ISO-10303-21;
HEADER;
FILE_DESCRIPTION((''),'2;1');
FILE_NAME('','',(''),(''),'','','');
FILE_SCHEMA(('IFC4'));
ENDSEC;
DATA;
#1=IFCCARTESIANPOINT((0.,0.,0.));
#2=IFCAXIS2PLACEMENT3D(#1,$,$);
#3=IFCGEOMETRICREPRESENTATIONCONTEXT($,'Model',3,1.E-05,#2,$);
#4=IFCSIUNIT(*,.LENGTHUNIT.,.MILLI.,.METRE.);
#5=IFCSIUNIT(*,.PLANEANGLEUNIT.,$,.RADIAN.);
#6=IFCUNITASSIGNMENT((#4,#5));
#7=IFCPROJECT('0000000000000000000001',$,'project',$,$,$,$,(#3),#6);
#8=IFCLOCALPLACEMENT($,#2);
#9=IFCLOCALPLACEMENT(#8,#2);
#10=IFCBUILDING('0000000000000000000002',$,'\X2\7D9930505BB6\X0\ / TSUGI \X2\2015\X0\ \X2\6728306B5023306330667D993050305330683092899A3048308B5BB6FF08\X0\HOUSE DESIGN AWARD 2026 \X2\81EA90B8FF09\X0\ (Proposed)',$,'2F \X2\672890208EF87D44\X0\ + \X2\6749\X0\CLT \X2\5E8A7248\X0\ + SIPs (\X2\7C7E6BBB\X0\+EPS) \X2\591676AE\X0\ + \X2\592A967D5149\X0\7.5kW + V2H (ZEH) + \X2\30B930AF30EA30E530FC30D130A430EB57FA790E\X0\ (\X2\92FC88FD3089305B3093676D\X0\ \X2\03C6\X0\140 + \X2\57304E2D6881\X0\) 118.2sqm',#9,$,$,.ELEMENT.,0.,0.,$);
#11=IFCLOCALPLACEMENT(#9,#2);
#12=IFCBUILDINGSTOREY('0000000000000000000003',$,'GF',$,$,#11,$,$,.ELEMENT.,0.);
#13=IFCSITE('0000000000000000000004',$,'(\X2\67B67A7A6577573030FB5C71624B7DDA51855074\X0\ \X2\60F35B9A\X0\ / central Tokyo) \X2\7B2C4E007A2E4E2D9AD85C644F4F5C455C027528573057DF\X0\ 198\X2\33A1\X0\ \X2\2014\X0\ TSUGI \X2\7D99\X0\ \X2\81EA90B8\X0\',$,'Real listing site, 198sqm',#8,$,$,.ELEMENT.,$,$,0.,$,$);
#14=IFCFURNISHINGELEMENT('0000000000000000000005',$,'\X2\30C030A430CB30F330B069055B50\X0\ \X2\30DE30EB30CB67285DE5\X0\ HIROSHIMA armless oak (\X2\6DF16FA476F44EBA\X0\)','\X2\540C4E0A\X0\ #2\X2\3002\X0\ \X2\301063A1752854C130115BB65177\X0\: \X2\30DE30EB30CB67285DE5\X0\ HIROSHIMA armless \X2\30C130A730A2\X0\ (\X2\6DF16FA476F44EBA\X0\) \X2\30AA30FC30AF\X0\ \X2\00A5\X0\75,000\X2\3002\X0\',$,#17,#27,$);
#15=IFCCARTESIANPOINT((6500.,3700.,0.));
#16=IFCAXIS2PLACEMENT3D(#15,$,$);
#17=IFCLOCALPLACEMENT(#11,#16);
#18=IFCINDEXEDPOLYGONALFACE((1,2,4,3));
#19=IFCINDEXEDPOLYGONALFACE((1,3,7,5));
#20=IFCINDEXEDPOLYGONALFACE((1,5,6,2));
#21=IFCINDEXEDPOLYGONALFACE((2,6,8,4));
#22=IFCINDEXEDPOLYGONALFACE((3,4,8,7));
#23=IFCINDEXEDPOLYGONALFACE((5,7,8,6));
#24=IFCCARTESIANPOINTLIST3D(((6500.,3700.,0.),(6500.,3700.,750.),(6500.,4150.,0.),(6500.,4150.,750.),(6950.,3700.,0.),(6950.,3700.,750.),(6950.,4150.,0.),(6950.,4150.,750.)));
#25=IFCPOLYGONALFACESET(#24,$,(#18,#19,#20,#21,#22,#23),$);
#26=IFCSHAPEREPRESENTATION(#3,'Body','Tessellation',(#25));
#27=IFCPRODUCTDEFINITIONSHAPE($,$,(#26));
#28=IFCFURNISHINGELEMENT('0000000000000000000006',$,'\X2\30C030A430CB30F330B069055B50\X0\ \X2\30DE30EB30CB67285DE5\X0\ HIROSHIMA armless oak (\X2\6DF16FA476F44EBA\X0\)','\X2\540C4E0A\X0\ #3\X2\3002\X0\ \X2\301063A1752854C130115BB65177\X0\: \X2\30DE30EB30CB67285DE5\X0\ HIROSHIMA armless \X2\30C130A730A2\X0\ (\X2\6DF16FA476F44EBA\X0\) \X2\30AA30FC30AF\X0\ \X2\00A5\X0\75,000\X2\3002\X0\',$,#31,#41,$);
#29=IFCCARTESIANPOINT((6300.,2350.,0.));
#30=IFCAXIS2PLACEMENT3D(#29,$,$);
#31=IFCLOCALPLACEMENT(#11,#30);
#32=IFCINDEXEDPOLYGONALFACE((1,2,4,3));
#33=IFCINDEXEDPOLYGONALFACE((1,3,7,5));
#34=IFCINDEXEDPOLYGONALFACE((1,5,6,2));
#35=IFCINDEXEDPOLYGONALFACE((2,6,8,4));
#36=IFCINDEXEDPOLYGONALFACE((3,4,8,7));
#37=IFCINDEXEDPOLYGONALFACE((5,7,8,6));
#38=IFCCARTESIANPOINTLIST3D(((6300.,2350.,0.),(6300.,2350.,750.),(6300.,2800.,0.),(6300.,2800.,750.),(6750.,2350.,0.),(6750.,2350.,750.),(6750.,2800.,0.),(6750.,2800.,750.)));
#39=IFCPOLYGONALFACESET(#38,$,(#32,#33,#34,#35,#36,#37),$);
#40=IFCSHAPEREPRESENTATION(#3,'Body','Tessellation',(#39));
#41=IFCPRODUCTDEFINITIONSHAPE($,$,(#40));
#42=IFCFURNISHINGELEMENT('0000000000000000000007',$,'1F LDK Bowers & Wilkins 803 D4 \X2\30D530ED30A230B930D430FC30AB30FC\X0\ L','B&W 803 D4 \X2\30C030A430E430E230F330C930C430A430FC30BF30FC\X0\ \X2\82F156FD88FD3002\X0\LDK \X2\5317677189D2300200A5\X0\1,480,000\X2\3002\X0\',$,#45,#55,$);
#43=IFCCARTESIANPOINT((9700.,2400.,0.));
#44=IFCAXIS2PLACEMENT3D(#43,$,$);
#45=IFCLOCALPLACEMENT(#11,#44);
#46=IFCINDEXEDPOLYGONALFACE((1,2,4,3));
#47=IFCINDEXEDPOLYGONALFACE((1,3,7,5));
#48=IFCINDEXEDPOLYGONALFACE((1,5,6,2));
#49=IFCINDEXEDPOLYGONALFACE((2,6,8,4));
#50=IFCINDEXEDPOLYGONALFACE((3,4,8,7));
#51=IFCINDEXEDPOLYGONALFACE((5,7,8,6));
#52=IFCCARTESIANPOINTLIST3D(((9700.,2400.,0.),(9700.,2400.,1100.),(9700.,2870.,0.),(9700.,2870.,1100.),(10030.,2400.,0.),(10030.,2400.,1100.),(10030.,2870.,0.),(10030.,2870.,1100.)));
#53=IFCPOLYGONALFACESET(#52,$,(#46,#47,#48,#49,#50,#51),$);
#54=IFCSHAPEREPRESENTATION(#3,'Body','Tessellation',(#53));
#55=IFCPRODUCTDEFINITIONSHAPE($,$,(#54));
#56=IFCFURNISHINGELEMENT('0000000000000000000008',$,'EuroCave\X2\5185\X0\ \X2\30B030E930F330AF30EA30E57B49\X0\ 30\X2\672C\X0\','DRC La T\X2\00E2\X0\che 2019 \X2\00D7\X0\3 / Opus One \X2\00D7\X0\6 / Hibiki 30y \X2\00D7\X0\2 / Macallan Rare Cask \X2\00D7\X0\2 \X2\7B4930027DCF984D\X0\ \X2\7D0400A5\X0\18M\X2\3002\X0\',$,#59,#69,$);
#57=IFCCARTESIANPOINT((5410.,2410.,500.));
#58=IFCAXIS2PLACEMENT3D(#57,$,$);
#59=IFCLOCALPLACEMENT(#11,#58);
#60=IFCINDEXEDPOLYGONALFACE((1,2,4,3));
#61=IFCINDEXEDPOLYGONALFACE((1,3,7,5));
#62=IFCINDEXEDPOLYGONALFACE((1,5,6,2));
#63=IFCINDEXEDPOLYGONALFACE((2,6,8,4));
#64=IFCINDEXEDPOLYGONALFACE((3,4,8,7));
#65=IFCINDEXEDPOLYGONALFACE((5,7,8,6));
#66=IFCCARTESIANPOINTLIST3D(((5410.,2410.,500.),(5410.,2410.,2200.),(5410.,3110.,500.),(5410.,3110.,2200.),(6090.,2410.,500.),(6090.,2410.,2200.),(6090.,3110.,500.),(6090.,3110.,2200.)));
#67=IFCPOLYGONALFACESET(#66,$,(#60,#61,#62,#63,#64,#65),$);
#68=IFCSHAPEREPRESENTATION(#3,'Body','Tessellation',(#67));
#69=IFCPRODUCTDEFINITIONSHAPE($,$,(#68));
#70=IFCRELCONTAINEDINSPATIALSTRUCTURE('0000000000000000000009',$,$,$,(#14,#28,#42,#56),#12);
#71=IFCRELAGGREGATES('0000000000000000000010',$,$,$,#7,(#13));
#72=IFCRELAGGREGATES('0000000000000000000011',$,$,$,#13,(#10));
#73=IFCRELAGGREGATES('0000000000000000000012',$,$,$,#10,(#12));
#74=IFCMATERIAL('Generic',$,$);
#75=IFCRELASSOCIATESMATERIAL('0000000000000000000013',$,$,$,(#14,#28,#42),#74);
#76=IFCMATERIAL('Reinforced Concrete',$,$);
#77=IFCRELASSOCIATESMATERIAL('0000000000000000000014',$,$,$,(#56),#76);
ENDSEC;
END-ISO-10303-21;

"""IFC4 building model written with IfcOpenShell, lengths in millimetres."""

from ifc_helpers import new_model, si_unit, frame, frame_2d, origin, place, context, project, spatial, rectangle, extrude, material, element, save


model = new_model("IFC4")

# Units and contexts
model_context = context("Model", 3, precision=1e-05, world=origin())
ifc_project = project(units=[si_unit("LENGTHUNIT", "METRE", prefix="MILLI"), si_unit("PLANEANGLEUNIT", "RADIAN")], contexts=[model_context])

# Site, building, storey
site_placement = place(None, origin())
site = spatial("IfcSite", under=ifc_project, at=site_placement, Name="(架空敷地・山手線内側 想定 / central Tokyo) 第一種中高層住居専用地域 198㎡ — TSUGI 継 自邸", ObjectType="Real listing site, 198sqm", CompositionType="ELEMENT", RefElevation=0.0)
building_placement = place(site_placement, origin())
building = spatial("IfcBuilding", under=site, at=building_placement, Name="継ぐ家 / TSUGI ― 木に倣って継ぐことを覚える家（HOUSE DESIGN AWARD 2026 自邸） (Proposed)", ObjectType="2F 木造軸組 + 杉CLT 床版 + SIPs (籾殻+EPS) 外皮 + 太陽光7.5kW + V2H (ZEH) + スクリューパイル基礎 (鋼製らせん杭 φ140 + 地中梁) 118.2sqm", CompositionType="ELEMENT", ElevationOfRefHeight=0.0, ElevationOfTerrain=0.0)
storey_placement = place(building_placement, origin())
storey = spatial("IfcBuildingStorey", under=building, at=storey_placement, Name="GF", CompositionType="ELEMENT", Elevation=0.0)

# Shared definitions
ifc_material_1 = material(Name="Generic")

# Furnishing elements
furnishing_1_placement = place(storey_placement, frame((6500.0, 3700.0, 0.0)))
element("IfcFurnishingElement", 1, at=furnishing_1_placement, inside=storey, material=ifc_material_1, Name="ダイニング椅子 マルニ木工 HIROSHIMA armless oak (深澤直人)", Description="同上 #2。 【採用品】家具: マルニ木工 HIROSHIMA armless チェア (深澤直人) オーク ¥75,000。", context=model_context, shape_type="SweptSolid", body=[
    extrude(rectangle(XDim=450.0, YDim=450.0, at=frame_2d((225.0, 225.0))), frame((6500.0, 3700.0, 0.0)), (0.0, 0.0, 1.0), 750.0),
])
furnishing_2_placement = place(storey_placement, frame((6300.0, 2350.0, 0.0)))
element("IfcFurnishingElement", 2, at=furnishing_2_placement, inside=storey, material=ifc_material_1, Name="ダイニング椅子 マルニ木工 HIROSHIMA armless oak (深澤直人)", Description="同上 #3。 【採用品】家具: マルニ木工 HIROSHIMA armless チェア (深澤直人) オーク ¥75,000。", context=model_context, shape_type="SweptSolid", body=[
    extrude(rectangle(XDim=450.0, YDim=450.0, at=frame_2d((225.0, 225.0))), frame((6300.0, 2350.0, 0.0)), (0.0, 0.0, 1.0), 750.0),
])
furnishing_3_placement = place(storey_placement, frame((9700.0, 2400.0, 0.0)))
element("IfcFurnishingElement", 3, at=furnishing_3_placement, inside=storey, material=ifc_material_1, Name="1F LDK Bowers & Wilkins 803 D4 フロアスピーカー L", Description="B&W 803 D4 ダイヤモンドツイーター 英国製。LDK 北東角。¥1,480,000。", context=model_context, shape_type="SweptSolid", body=[
    extrude(rectangle(XDim=330.0, YDim=470.0, at=frame_2d((165.0, 235.0))), frame((9700.0, 2400.0, 0.0)), (0.0, 0.0, 1.0), 1100.0),
])
ifc_material_2 = material(Name="Reinforced Concrete")
furnishing_4_placement = place(storey_placement, frame((5410.0, 2410.0, 500.0)))
element("IfcFurnishingElement", 4, at=furnishing_4_placement, inside=storey, material=ifc_material_2, Name="EuroCave内 グランクリュ等 30本", Description="DRC La Tâche 2019 ×3 / Opus One ×6 / Hibiki 30y ×2 / Macallan Rare Cask ×2 等。総額 約¥18M。", context=model_context, shape_type="SweptSolid", body=[
    extrude(rectangle(XDim=680.0, YDim=700.0, at=frame_2d((340.0, 350.0))), frame((5410.0, 2410.0, 500.0)), (0.0, 0.0, 1.0), 1700.0),
])

save(model, "model.ifc")
